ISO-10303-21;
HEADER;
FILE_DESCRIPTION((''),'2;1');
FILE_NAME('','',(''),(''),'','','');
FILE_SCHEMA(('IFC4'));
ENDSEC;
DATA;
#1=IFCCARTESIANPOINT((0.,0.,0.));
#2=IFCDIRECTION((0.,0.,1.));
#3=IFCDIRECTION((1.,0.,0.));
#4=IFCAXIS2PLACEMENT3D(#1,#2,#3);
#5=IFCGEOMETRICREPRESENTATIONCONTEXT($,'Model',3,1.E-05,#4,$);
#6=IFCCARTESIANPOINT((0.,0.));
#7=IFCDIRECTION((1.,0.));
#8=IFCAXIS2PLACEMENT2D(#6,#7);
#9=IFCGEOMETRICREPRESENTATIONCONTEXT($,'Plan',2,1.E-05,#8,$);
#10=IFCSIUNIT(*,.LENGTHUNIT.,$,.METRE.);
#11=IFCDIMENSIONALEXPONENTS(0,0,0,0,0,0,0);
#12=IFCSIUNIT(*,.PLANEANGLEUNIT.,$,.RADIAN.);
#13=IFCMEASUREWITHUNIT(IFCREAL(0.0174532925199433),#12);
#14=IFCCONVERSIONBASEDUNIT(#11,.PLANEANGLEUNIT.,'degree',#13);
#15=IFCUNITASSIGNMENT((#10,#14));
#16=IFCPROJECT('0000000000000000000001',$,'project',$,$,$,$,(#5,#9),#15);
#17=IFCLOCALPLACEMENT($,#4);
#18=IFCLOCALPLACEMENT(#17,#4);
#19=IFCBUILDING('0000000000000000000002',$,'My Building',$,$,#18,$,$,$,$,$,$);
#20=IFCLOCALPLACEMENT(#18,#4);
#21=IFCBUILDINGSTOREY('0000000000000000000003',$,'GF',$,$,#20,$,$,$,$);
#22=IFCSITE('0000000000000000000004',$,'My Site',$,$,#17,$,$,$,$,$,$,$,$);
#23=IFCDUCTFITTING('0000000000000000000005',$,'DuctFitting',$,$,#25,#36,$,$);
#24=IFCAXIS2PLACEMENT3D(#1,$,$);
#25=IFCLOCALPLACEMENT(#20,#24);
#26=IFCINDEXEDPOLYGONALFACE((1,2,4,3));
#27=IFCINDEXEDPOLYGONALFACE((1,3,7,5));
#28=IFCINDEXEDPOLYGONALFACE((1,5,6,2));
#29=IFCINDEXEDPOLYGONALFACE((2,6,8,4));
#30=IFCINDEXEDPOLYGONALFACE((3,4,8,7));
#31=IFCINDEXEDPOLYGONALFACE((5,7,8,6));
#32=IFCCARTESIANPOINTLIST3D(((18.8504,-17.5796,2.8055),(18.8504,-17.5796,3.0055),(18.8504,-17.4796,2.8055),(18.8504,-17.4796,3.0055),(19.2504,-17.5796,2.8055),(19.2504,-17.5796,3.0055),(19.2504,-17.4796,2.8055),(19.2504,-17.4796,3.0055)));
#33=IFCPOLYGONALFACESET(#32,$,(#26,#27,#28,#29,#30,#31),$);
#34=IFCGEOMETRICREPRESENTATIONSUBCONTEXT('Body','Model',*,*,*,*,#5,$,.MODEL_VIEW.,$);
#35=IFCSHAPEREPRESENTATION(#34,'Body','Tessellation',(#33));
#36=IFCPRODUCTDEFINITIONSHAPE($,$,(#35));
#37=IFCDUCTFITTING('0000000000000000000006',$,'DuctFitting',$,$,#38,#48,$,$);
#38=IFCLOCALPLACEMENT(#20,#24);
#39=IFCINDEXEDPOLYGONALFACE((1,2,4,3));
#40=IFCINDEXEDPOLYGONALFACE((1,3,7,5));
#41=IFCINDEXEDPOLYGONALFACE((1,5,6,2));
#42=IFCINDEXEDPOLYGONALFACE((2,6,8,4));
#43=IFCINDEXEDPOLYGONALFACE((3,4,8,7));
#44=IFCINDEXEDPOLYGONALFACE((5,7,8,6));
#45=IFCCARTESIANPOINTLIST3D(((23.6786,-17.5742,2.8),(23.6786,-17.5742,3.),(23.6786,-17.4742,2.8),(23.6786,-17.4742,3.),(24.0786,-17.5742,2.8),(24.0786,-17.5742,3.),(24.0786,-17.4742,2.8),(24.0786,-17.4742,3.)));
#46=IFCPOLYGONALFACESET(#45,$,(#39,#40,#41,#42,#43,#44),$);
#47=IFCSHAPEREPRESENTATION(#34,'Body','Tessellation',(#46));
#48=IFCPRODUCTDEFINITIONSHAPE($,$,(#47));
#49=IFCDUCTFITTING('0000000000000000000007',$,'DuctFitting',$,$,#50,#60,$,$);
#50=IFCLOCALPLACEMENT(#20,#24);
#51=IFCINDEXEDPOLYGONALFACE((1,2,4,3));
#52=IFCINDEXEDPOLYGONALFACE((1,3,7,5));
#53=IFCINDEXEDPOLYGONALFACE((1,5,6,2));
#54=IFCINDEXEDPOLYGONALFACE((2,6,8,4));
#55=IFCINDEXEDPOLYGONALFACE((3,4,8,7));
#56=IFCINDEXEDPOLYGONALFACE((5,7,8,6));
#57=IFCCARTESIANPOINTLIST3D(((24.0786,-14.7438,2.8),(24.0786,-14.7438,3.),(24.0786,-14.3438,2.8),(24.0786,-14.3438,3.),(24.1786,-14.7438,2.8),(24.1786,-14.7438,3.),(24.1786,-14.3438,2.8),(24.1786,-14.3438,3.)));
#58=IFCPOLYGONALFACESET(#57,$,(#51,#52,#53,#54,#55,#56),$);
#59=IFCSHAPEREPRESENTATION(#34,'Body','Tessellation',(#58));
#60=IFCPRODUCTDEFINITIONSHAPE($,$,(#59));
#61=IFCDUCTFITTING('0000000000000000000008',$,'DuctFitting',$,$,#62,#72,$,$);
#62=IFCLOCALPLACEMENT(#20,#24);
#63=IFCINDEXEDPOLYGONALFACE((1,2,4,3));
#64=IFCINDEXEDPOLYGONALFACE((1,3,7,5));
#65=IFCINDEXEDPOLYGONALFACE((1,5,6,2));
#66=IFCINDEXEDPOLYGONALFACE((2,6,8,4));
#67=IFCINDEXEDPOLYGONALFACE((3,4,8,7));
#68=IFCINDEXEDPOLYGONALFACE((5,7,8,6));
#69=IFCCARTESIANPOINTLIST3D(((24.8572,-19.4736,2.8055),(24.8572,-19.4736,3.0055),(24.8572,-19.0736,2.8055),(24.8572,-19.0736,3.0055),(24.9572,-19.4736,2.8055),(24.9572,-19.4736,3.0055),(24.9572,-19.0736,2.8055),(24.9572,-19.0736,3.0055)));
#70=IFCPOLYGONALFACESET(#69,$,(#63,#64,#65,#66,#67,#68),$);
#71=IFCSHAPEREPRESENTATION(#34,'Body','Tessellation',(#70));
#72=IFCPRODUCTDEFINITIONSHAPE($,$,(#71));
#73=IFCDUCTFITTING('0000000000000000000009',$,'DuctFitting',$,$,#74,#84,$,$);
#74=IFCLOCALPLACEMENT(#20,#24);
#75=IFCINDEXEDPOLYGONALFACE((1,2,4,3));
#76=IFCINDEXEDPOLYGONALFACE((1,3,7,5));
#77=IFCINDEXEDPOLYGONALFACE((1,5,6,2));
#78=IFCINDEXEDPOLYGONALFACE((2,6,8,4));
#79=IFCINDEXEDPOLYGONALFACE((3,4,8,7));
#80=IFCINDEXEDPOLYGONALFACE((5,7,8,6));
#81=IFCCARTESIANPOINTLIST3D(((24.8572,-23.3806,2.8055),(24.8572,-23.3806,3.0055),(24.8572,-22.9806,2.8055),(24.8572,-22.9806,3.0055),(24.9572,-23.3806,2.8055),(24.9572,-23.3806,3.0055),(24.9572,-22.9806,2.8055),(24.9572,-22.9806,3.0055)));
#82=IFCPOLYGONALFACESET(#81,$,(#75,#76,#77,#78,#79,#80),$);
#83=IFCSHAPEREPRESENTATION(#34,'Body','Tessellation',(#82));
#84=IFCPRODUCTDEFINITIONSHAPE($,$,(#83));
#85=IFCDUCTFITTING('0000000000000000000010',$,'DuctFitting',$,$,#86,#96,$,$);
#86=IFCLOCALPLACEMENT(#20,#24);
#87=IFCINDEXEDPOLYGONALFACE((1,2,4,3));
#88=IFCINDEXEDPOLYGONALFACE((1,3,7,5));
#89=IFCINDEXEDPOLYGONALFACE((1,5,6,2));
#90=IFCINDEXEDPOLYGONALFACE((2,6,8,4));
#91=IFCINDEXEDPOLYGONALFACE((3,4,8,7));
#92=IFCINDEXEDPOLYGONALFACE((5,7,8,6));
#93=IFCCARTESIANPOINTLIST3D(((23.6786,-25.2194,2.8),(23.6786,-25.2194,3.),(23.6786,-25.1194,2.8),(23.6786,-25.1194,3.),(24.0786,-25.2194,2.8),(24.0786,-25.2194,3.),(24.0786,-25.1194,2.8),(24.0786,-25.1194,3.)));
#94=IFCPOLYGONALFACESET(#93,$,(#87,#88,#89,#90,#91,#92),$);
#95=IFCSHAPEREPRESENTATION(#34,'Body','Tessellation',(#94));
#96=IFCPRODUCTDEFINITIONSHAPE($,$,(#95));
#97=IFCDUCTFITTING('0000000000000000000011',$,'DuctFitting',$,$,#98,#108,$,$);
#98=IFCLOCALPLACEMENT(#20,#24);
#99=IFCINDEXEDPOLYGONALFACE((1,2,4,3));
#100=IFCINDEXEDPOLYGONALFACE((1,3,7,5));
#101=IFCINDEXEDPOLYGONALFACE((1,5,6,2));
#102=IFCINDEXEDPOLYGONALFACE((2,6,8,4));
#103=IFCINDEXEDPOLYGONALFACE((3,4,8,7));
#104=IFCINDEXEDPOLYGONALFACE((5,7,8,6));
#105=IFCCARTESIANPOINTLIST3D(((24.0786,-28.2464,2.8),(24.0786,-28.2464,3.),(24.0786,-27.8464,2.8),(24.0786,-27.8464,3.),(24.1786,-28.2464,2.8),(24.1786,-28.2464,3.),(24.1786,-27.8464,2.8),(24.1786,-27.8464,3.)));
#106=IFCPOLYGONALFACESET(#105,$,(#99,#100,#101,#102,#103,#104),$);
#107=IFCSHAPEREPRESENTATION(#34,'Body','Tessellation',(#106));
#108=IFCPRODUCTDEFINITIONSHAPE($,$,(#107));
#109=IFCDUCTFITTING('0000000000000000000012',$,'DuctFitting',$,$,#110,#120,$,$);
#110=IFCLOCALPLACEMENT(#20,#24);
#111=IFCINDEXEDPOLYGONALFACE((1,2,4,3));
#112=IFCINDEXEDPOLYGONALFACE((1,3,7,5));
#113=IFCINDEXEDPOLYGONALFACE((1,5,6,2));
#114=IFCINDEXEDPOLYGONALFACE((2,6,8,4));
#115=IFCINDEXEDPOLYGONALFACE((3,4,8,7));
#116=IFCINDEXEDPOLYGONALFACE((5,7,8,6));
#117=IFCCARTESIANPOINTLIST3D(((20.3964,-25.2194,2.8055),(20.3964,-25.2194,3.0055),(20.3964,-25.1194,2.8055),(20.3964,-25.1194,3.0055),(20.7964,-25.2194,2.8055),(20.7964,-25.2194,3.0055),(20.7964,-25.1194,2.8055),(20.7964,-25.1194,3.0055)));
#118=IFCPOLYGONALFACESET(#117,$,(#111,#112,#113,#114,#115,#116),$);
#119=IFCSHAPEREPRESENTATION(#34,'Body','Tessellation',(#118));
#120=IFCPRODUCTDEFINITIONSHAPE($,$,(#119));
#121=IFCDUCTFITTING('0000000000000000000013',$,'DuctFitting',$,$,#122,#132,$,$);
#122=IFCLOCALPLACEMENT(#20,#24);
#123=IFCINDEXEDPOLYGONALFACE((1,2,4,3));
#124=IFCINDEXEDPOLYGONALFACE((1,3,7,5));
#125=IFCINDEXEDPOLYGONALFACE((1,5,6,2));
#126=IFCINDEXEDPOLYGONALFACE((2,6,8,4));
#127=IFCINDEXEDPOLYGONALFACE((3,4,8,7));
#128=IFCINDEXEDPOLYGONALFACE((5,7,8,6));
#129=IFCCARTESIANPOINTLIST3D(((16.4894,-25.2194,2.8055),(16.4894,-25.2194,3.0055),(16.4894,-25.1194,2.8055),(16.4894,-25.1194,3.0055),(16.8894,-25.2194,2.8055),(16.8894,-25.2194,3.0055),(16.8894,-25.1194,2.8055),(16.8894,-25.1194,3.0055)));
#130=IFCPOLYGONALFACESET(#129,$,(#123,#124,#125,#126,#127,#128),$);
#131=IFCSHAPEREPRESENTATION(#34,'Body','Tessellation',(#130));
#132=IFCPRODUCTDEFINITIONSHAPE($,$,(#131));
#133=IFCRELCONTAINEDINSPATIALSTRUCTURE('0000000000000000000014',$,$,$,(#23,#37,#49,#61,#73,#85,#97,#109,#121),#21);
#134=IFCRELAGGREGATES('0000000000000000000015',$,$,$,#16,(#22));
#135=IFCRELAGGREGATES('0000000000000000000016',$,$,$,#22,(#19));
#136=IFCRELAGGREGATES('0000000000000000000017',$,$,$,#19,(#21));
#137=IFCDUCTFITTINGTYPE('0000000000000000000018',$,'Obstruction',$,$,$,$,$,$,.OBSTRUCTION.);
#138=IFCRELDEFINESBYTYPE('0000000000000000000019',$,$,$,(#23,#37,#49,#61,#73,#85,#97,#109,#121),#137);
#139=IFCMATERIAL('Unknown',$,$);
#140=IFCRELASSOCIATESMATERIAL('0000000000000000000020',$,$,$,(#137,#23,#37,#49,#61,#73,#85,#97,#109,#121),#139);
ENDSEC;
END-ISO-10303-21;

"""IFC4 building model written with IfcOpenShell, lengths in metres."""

from ifc_helpers import new_model, entity, si_unit, converted_unit, frame, origin_with_axes, origin_2d_with_axis, place, context, subcontext, project, spatial, rectangle, extrude, material, material_profile, profile_set, profile_usage, type_object, element, save


model = new_model("IFC4")

# Units and contexts
model_context = context("Model", 3, precision=1e-05, world=origin_with_axes())
plan_context = context("Plan", 2, precision=1e-05, world=origin_2d_with_axis())
body_context_1 = subcontext(model_context, "Body", "Model", "MODEL_VIEW")
ifc_project = project(units=[si_unit("LENGTHUNIT", "METRE"), converted_unit("PLANEANGLEUNIT", "degree", entity("IfcReal", 0.0174532925199433), si_unit("PLANEANGLEUNIT", "RADIAN"), dimensions=[0, 0, 0, 0, 0, 0, 0])], contexts=[model_context, plan_context])

# Site, building, storey
site_placement = place(None, origin_with_axes())
site = spatial("IfcSite", under=ifc_project, at=site_placement, Name="My Site")
building_placement = place(site_placement, origin_with_axes())
building = spatial("IfcBuilding", under=site, at=building_placement, Name="My Building")
storey_placement = place(building_placement, origin_with_axes())
storey = spatial("IfcBuildingStorey", under=building, at=storey_placement, Name="GF")

# Shared definitions
ifc_material = material(Name="Unknown")

# Duct fittings
ifc_material_profile = material_profile(ifc_material, rectangle(XDim=0.4, YDim=0.2))
ifc_profile_set = profile_set([ifc_material_profile])
duct_fitting_type = type_object("IfcDuctFittingType", Name="Obstruction", PredefinedType="OBSTRUCTION", material=ifc_profile_set)
ifc_profile_usage_1 = profile_usage(ifc_profile_set, cardinal=5)
duct_fitting_1_placement = place(storey_placement, frame((19.0504, -17.5796, 2.9055), z_axis=(0.0, 1.0, 0.0), x_axis=(-1.0, 0.0, 0.0)))
element("IfcDuctFitting", 1, at=duct_fitting_1_placement, inside=storey, type_object=duct_fitting_type, material=ifc_profile_usage_1, Name="DuctFitting", context=body_context_1, shape_type="SweptSolid", body=[
    extrude(rectangle(XDim=0.4, YDim=0.2), origin_with_axes(), (0.0, 0.0, 1.0), 0.1),
])
ifc_profile_usage_2 = profile_usage(ifc_profile_set, cardinal=5)
duct_fitting_2_placement = place(storey_placement, frame((23.8786, -17.5742, 2.9), z_axis=(0.0, 1.0, 0.0), x_axis=(-1.0, 0.0, 0.0)))
element("IfcDuctFitting", 2, at=duct_fitting_2_placement, inside=storey, type_object=duct_fitting_type, material=ifc_profile_usage_2, Name="DuctFitting", context=body_context_1, shape_type="SweptSolid", body=[
    extrude(rectangle(XDim=0.4, YDim=0.2), origin_with_axes(), (0.0, 0.0, 1.0), 0.1),
])
ifc_profile_usage_3 = profile_usage(ifc_profile_set, cardinal=5)
duct_fitting_3_placement = place(storey_placement, frame((24.0786, -14.5438, 2.9), z_axis=(1.0, 0.0, 0.0), x_axis=(0.0, 1.0, 0.0)))
element("IfcDuctFitting", 3, at=duct_fitting_3_placement, inside=storey, type_object=duct_fitting_type, material=ifc_profile_usage_3, Name="DuctFitting", context=body_context_1, shape_type="SweptSolid", body=[
    extrude(rectangle(XDim=0.4, YDim=0.2), origin_with_axes(), (0.0, 0.0, 1.0), 0.1),
])
ifc_profile_usage_4 = profile_usage(ifc_profile_set, cardinal=5)
duct_fitting_4_placement = place(storey_placement, frame((24.8572, -19.2736, 2.9055), z_axis=(1.0, 0.0, 0.0), x_axis=(0.0, 1.0, 0.0)))
element("IfcDuctFitting", 4, at=duct_fitting_4_placement, inside=storey, type_object=duct_fitting_type, material=ifc_profile_usage_4, Name="DuctFitting", context=body_context_1, shape_type="SweptSolid", body=[
    extrude(rectangle(XDim=0.4, YDim=0.2), origin_with_axes(), (0.0, 0.0, 1.0), 0.1),
])
ifc_profile_usage_5 = profile_usage(ifc_profile_set, cardinal=5)
duct_fitting_5_placement = place(storey_placement, frame((24.8572, -23.1806, 2.9055), z_axis=(1.0, 0.0, 0.0), x_axis=(0.0, 1.0, 0.0)))
element("IfcDuctFitting", 5, at=duct_fitting_5_placement, inside=storey, type_object=duct_fitting_type, material=ifc_profile_usage_5, Name="DuctFitting", context=body_context_1, shape_type="SweptSolid", body=[
    extrude(rectangle(XDim=0.4, YDim=0.2), origin_with_axes(), (0.0, 0.0, 1.0), 0.1),
])
ifc_profile_usage_6 = profile_usage(ifc_profile_set, cardinal=5)
duct_fitting_6_placement = place(storey_placement, frame((23.8786, -25.1194, 2.9), z_axis=(0.0, -1.0, 0.0), x_axis=(1.0, 0.0, 0.0)))
element("IfcDuctFitting", 6, at=duct_fitting_6_placement, inside=storey, type_object=duct_fitting_type, material=ifc_profile_usage_6, Name="DuctFitting", context=body_context_1, shape_type="SweptSolid", body=[
    extrude(rectangle(XDim=0.4, YDim=0.2), origin_with_axes(), (0.0, 0.0, 1.0), 0.1),
])
ifc_profile_usage_7 = profile_usage(ifc_profile_set, cardinal=5)
duct_fitting_7_placement = place(storey_placement, frame((24.0786, -28.0464, 2.9), z_axis=(1.0, 0.0, 0.0), x_axis=(0.0, 1.0, 0.0)))
element("IfcDuctFitting", 7, at=duct_fitting_7_placement, inside=storey, type_object=duct_fitting_type, material=ifc_profile_usage_7, Name="DuctFitting", context=body_context_1, shape_type="SweptSolid", body=[
    extrude(rectangle(XDim=0.4, YDim=0.2), origin_with_axes(), (0.0, 0.0, 1.0), 0.1),
])
ifc_profile_usage_8 = profile_usage(ifc_profile_set, cardinal=5)
duct_fitting_8_placement = place(storey_placement, frame((20.5964, -25.1194, 2.9055), z_axis=(0.0, -1.0, 0.0), x_axis=(1.0, 0.0, 0.0)))
element("IfcDuctFitting", 8, at=duct_fitting_8_placement, inside=storey, type_object=duct_fitting_type, material=ifc_profile_usage_8, Name="DuctFitting", context=body_context_1, shape_type="SweptSolid", body=[
    extrude(rectangle(XDim=0.4, YDim=0.2), origin_with_axes(), (0.0, 0.0, 1.0), 0.1),
])
ifc_profile_usage_9 = profile_usage(ifc_profile_set, cardinal=5)
duct_fitting_9_placement = place(storey_placement, frame((16.6894, -25.1194, 2.9055), z_axis=(0.0, -1.0, 0.0), x_axis=(1.0, 0.0, 0.0)))
element("IfcDuctFitting", 9, at=duct_fitting_9_placement, inside=storey, type_object=duct_fitting_type, material=ifc_profile_usage_9, Name="DuctFitting", context=body_context_1, shape_type="SweptSolid", body=[
    extrude(rectangle(XDim=0.4, YDim=0.2), origin_with_axes(), (0.0, 0.0, 1.0), 0.1),
])

save(model, "model.ifc")
